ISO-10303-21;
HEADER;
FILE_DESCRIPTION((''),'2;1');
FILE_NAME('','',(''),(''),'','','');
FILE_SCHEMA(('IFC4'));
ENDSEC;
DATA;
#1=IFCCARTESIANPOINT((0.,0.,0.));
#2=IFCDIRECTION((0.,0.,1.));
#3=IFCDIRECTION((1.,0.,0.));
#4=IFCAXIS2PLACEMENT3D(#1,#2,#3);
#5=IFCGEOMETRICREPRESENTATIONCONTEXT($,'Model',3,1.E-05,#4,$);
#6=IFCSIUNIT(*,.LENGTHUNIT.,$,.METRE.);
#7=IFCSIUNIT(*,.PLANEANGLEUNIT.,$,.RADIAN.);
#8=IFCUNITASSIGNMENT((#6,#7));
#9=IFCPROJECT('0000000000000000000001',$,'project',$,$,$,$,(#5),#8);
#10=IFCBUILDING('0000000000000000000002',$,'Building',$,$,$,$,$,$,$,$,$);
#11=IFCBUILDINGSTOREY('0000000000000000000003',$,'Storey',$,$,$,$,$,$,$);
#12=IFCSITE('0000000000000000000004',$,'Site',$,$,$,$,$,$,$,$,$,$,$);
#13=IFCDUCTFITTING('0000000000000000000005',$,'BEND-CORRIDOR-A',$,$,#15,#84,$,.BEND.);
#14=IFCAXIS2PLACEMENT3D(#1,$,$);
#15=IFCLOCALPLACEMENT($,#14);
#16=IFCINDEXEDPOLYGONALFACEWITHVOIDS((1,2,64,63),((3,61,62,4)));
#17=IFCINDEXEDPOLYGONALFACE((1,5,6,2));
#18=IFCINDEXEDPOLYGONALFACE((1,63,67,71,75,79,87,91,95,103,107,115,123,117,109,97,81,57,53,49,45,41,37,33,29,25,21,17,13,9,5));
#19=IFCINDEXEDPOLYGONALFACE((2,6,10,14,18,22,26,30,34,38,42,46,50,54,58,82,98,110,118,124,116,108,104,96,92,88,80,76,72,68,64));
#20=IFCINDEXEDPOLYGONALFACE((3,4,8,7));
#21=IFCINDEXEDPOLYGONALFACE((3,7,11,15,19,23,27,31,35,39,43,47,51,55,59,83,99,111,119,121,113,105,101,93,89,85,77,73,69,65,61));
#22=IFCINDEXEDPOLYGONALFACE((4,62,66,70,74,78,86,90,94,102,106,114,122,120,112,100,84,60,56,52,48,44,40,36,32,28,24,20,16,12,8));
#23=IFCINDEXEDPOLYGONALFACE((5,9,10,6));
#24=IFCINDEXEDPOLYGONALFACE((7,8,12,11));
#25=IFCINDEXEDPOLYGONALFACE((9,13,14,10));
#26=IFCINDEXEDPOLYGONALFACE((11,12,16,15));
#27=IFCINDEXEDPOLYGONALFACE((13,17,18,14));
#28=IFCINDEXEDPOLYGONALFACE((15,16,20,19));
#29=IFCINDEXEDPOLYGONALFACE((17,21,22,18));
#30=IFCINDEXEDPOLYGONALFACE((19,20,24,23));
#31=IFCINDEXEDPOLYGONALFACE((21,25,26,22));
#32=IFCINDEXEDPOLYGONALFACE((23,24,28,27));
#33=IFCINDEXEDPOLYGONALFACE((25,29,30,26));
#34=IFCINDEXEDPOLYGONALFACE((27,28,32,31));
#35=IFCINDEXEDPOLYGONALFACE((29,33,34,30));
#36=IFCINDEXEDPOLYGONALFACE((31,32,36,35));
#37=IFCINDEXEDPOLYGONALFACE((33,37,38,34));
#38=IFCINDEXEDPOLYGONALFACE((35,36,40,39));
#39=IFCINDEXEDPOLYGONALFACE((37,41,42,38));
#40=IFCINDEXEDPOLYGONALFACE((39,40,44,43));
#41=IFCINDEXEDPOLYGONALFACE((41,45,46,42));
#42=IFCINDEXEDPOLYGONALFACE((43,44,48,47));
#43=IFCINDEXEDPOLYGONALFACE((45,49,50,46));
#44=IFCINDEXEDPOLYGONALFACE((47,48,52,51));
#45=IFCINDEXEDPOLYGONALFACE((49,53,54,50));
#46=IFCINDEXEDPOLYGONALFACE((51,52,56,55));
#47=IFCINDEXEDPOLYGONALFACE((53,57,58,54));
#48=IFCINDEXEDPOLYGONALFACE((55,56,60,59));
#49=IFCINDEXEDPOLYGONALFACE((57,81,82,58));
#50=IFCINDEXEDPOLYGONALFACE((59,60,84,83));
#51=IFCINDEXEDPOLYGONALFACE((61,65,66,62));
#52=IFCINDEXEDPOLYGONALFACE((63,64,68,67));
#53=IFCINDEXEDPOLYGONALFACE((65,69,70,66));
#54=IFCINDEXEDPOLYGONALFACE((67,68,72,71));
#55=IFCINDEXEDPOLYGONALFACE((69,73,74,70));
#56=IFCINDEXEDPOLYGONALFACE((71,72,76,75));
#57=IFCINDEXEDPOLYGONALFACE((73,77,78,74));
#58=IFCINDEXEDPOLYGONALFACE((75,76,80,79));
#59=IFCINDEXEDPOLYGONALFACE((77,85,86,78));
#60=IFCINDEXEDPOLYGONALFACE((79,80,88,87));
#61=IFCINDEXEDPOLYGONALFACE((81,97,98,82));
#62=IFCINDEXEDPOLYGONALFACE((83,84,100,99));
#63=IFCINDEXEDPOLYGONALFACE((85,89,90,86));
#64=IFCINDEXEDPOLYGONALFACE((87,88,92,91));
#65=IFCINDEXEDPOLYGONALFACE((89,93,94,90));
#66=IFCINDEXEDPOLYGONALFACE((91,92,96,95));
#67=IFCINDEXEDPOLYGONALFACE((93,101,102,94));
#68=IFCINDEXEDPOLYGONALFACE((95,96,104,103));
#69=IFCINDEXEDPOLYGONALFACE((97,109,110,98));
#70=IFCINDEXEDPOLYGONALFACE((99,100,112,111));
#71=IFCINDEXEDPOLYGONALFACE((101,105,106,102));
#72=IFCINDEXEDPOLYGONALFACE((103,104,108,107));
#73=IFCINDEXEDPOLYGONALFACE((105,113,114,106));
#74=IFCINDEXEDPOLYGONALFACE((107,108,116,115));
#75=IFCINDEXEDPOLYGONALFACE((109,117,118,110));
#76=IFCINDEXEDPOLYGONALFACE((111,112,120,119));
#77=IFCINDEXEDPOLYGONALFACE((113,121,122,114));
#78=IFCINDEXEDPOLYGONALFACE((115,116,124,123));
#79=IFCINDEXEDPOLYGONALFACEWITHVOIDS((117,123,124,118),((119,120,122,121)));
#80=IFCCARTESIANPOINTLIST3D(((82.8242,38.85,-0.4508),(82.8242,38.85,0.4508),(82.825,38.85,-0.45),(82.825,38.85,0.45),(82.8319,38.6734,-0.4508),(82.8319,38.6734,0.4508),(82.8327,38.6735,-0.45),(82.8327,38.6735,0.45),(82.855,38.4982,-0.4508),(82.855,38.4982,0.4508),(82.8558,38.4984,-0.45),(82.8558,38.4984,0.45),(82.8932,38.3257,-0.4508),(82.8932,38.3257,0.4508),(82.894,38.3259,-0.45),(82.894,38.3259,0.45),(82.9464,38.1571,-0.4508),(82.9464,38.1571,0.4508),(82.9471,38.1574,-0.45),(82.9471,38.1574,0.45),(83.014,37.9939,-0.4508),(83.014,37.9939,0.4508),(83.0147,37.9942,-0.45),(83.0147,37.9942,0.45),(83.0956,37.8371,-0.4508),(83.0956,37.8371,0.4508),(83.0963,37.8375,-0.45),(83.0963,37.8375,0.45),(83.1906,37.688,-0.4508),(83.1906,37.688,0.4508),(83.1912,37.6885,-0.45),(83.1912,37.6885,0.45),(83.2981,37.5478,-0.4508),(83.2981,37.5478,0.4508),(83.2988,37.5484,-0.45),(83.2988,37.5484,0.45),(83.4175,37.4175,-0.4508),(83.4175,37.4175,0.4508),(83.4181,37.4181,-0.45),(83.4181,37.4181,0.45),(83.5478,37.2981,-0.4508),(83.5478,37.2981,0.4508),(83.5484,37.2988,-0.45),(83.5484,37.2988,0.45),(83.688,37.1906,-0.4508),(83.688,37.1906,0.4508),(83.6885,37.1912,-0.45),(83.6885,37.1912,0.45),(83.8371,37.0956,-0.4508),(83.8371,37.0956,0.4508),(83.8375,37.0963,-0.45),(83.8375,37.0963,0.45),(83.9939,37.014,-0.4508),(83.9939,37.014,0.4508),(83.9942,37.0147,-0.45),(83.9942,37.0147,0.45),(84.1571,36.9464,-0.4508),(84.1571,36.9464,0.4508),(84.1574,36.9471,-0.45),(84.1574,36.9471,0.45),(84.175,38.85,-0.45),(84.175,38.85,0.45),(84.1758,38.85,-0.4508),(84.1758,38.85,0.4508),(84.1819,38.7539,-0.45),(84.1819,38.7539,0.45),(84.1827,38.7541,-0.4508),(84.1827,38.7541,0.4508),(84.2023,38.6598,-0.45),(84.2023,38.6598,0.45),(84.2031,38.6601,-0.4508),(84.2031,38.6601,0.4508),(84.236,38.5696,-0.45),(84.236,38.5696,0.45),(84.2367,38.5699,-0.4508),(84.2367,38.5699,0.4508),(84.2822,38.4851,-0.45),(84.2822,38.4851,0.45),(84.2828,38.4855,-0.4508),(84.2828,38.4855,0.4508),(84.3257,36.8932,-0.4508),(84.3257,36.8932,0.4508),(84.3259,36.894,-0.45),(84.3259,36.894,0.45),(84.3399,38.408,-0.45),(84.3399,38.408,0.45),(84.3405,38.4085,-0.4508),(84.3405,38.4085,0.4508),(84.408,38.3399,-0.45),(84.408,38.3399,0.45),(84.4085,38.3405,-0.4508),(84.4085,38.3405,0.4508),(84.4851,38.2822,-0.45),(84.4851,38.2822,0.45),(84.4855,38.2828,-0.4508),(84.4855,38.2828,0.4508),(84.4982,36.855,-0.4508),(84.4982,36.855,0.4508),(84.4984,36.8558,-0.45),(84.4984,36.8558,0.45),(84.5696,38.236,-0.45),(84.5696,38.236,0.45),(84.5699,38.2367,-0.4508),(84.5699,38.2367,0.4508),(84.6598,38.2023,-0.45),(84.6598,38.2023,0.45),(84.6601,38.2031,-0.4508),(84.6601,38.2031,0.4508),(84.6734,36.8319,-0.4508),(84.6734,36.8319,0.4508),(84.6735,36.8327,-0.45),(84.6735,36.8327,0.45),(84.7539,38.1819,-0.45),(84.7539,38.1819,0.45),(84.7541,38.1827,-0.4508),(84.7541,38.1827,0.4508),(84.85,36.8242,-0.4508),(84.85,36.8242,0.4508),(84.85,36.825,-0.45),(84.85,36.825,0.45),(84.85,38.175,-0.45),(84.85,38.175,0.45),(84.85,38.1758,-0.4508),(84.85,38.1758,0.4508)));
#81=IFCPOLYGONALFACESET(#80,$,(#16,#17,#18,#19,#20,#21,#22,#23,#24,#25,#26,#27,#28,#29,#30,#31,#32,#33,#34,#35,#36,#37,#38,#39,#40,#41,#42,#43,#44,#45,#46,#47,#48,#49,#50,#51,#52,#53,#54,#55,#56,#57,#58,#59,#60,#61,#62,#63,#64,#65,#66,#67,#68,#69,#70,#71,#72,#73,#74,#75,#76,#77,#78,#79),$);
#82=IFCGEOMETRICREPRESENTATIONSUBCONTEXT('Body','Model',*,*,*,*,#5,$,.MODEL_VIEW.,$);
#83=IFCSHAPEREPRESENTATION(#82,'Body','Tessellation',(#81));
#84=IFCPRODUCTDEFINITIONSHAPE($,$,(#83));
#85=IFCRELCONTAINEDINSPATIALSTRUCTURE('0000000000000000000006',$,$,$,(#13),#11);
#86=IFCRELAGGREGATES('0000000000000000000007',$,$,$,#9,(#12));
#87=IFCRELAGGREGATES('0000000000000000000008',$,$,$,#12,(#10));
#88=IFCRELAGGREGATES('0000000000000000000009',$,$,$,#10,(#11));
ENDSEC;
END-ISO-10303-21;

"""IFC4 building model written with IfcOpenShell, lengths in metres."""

from ifc_helpers import new_model, entity, si_unit, frame, origin_with_axes, place, context, subcontext, project, spatial, element, save


model = new_model("IFC4")

# Units and contexts
model_context = context("Model", 3, precision=1e-05, world=origin_with_axes())
body_context = subcontext(model_context, "Body", "Model", "MODEL_VIEW")
ifc_project = project(units=[si_unit("LENGTHUNIT", "METRE"), si_unit("PLANEANGLEUNIT", "RADIAN")], contexts=[model_context])

# Site, building, storey
site = spatial("IfcSite", under=ifc_project, Name="Site")
building = spatial("IfcBuilding", under=site, Name="Building")
storey = spatial("IfcBuildingStorey", under=building, Name="Storey")

# Duct fitting
duct_fitting_1_placement = place(None, frame((84.85, 38.85, 0.0), z_axis=(0.0, 0.0, 1.0), x_axis=(-1.0, 0.0, 0.0)))
cartesian_point_1 = entity("IfcCartesianPoint", [0.0, 0.0, 0.0])
element("IfcDuctFitting", 1, at=duct_fitting_1_placement, inside=storey, Name="BEND-CORRIDOR-A", PredefinedType="BEND", context=body_context, shape_type="SweptSolid", body=[
    entity("IfcRevolvedAreaSolid", entity("IfcRectangleHollowProfileDef", "AREA", None, entity("IfcAxis2Placement2D", entity("IfcCartesianPoint", [1.35, 0.0])), 1.3516, 0.9016, 0.0008), entity("IfcAxis2Placement3D", cartesian_point_1, entity("IfcDirection", [0.0, -1.0, 0.0]), entity("IfcDirection", [1.0, 0.0, 0.0])), entity("IfcAxis1Placement", cartesian_point_1, entity("IfcDirection", [0.0, 1.0, 0.0])), 1.570796),
])

save(model, "model.ifc")
